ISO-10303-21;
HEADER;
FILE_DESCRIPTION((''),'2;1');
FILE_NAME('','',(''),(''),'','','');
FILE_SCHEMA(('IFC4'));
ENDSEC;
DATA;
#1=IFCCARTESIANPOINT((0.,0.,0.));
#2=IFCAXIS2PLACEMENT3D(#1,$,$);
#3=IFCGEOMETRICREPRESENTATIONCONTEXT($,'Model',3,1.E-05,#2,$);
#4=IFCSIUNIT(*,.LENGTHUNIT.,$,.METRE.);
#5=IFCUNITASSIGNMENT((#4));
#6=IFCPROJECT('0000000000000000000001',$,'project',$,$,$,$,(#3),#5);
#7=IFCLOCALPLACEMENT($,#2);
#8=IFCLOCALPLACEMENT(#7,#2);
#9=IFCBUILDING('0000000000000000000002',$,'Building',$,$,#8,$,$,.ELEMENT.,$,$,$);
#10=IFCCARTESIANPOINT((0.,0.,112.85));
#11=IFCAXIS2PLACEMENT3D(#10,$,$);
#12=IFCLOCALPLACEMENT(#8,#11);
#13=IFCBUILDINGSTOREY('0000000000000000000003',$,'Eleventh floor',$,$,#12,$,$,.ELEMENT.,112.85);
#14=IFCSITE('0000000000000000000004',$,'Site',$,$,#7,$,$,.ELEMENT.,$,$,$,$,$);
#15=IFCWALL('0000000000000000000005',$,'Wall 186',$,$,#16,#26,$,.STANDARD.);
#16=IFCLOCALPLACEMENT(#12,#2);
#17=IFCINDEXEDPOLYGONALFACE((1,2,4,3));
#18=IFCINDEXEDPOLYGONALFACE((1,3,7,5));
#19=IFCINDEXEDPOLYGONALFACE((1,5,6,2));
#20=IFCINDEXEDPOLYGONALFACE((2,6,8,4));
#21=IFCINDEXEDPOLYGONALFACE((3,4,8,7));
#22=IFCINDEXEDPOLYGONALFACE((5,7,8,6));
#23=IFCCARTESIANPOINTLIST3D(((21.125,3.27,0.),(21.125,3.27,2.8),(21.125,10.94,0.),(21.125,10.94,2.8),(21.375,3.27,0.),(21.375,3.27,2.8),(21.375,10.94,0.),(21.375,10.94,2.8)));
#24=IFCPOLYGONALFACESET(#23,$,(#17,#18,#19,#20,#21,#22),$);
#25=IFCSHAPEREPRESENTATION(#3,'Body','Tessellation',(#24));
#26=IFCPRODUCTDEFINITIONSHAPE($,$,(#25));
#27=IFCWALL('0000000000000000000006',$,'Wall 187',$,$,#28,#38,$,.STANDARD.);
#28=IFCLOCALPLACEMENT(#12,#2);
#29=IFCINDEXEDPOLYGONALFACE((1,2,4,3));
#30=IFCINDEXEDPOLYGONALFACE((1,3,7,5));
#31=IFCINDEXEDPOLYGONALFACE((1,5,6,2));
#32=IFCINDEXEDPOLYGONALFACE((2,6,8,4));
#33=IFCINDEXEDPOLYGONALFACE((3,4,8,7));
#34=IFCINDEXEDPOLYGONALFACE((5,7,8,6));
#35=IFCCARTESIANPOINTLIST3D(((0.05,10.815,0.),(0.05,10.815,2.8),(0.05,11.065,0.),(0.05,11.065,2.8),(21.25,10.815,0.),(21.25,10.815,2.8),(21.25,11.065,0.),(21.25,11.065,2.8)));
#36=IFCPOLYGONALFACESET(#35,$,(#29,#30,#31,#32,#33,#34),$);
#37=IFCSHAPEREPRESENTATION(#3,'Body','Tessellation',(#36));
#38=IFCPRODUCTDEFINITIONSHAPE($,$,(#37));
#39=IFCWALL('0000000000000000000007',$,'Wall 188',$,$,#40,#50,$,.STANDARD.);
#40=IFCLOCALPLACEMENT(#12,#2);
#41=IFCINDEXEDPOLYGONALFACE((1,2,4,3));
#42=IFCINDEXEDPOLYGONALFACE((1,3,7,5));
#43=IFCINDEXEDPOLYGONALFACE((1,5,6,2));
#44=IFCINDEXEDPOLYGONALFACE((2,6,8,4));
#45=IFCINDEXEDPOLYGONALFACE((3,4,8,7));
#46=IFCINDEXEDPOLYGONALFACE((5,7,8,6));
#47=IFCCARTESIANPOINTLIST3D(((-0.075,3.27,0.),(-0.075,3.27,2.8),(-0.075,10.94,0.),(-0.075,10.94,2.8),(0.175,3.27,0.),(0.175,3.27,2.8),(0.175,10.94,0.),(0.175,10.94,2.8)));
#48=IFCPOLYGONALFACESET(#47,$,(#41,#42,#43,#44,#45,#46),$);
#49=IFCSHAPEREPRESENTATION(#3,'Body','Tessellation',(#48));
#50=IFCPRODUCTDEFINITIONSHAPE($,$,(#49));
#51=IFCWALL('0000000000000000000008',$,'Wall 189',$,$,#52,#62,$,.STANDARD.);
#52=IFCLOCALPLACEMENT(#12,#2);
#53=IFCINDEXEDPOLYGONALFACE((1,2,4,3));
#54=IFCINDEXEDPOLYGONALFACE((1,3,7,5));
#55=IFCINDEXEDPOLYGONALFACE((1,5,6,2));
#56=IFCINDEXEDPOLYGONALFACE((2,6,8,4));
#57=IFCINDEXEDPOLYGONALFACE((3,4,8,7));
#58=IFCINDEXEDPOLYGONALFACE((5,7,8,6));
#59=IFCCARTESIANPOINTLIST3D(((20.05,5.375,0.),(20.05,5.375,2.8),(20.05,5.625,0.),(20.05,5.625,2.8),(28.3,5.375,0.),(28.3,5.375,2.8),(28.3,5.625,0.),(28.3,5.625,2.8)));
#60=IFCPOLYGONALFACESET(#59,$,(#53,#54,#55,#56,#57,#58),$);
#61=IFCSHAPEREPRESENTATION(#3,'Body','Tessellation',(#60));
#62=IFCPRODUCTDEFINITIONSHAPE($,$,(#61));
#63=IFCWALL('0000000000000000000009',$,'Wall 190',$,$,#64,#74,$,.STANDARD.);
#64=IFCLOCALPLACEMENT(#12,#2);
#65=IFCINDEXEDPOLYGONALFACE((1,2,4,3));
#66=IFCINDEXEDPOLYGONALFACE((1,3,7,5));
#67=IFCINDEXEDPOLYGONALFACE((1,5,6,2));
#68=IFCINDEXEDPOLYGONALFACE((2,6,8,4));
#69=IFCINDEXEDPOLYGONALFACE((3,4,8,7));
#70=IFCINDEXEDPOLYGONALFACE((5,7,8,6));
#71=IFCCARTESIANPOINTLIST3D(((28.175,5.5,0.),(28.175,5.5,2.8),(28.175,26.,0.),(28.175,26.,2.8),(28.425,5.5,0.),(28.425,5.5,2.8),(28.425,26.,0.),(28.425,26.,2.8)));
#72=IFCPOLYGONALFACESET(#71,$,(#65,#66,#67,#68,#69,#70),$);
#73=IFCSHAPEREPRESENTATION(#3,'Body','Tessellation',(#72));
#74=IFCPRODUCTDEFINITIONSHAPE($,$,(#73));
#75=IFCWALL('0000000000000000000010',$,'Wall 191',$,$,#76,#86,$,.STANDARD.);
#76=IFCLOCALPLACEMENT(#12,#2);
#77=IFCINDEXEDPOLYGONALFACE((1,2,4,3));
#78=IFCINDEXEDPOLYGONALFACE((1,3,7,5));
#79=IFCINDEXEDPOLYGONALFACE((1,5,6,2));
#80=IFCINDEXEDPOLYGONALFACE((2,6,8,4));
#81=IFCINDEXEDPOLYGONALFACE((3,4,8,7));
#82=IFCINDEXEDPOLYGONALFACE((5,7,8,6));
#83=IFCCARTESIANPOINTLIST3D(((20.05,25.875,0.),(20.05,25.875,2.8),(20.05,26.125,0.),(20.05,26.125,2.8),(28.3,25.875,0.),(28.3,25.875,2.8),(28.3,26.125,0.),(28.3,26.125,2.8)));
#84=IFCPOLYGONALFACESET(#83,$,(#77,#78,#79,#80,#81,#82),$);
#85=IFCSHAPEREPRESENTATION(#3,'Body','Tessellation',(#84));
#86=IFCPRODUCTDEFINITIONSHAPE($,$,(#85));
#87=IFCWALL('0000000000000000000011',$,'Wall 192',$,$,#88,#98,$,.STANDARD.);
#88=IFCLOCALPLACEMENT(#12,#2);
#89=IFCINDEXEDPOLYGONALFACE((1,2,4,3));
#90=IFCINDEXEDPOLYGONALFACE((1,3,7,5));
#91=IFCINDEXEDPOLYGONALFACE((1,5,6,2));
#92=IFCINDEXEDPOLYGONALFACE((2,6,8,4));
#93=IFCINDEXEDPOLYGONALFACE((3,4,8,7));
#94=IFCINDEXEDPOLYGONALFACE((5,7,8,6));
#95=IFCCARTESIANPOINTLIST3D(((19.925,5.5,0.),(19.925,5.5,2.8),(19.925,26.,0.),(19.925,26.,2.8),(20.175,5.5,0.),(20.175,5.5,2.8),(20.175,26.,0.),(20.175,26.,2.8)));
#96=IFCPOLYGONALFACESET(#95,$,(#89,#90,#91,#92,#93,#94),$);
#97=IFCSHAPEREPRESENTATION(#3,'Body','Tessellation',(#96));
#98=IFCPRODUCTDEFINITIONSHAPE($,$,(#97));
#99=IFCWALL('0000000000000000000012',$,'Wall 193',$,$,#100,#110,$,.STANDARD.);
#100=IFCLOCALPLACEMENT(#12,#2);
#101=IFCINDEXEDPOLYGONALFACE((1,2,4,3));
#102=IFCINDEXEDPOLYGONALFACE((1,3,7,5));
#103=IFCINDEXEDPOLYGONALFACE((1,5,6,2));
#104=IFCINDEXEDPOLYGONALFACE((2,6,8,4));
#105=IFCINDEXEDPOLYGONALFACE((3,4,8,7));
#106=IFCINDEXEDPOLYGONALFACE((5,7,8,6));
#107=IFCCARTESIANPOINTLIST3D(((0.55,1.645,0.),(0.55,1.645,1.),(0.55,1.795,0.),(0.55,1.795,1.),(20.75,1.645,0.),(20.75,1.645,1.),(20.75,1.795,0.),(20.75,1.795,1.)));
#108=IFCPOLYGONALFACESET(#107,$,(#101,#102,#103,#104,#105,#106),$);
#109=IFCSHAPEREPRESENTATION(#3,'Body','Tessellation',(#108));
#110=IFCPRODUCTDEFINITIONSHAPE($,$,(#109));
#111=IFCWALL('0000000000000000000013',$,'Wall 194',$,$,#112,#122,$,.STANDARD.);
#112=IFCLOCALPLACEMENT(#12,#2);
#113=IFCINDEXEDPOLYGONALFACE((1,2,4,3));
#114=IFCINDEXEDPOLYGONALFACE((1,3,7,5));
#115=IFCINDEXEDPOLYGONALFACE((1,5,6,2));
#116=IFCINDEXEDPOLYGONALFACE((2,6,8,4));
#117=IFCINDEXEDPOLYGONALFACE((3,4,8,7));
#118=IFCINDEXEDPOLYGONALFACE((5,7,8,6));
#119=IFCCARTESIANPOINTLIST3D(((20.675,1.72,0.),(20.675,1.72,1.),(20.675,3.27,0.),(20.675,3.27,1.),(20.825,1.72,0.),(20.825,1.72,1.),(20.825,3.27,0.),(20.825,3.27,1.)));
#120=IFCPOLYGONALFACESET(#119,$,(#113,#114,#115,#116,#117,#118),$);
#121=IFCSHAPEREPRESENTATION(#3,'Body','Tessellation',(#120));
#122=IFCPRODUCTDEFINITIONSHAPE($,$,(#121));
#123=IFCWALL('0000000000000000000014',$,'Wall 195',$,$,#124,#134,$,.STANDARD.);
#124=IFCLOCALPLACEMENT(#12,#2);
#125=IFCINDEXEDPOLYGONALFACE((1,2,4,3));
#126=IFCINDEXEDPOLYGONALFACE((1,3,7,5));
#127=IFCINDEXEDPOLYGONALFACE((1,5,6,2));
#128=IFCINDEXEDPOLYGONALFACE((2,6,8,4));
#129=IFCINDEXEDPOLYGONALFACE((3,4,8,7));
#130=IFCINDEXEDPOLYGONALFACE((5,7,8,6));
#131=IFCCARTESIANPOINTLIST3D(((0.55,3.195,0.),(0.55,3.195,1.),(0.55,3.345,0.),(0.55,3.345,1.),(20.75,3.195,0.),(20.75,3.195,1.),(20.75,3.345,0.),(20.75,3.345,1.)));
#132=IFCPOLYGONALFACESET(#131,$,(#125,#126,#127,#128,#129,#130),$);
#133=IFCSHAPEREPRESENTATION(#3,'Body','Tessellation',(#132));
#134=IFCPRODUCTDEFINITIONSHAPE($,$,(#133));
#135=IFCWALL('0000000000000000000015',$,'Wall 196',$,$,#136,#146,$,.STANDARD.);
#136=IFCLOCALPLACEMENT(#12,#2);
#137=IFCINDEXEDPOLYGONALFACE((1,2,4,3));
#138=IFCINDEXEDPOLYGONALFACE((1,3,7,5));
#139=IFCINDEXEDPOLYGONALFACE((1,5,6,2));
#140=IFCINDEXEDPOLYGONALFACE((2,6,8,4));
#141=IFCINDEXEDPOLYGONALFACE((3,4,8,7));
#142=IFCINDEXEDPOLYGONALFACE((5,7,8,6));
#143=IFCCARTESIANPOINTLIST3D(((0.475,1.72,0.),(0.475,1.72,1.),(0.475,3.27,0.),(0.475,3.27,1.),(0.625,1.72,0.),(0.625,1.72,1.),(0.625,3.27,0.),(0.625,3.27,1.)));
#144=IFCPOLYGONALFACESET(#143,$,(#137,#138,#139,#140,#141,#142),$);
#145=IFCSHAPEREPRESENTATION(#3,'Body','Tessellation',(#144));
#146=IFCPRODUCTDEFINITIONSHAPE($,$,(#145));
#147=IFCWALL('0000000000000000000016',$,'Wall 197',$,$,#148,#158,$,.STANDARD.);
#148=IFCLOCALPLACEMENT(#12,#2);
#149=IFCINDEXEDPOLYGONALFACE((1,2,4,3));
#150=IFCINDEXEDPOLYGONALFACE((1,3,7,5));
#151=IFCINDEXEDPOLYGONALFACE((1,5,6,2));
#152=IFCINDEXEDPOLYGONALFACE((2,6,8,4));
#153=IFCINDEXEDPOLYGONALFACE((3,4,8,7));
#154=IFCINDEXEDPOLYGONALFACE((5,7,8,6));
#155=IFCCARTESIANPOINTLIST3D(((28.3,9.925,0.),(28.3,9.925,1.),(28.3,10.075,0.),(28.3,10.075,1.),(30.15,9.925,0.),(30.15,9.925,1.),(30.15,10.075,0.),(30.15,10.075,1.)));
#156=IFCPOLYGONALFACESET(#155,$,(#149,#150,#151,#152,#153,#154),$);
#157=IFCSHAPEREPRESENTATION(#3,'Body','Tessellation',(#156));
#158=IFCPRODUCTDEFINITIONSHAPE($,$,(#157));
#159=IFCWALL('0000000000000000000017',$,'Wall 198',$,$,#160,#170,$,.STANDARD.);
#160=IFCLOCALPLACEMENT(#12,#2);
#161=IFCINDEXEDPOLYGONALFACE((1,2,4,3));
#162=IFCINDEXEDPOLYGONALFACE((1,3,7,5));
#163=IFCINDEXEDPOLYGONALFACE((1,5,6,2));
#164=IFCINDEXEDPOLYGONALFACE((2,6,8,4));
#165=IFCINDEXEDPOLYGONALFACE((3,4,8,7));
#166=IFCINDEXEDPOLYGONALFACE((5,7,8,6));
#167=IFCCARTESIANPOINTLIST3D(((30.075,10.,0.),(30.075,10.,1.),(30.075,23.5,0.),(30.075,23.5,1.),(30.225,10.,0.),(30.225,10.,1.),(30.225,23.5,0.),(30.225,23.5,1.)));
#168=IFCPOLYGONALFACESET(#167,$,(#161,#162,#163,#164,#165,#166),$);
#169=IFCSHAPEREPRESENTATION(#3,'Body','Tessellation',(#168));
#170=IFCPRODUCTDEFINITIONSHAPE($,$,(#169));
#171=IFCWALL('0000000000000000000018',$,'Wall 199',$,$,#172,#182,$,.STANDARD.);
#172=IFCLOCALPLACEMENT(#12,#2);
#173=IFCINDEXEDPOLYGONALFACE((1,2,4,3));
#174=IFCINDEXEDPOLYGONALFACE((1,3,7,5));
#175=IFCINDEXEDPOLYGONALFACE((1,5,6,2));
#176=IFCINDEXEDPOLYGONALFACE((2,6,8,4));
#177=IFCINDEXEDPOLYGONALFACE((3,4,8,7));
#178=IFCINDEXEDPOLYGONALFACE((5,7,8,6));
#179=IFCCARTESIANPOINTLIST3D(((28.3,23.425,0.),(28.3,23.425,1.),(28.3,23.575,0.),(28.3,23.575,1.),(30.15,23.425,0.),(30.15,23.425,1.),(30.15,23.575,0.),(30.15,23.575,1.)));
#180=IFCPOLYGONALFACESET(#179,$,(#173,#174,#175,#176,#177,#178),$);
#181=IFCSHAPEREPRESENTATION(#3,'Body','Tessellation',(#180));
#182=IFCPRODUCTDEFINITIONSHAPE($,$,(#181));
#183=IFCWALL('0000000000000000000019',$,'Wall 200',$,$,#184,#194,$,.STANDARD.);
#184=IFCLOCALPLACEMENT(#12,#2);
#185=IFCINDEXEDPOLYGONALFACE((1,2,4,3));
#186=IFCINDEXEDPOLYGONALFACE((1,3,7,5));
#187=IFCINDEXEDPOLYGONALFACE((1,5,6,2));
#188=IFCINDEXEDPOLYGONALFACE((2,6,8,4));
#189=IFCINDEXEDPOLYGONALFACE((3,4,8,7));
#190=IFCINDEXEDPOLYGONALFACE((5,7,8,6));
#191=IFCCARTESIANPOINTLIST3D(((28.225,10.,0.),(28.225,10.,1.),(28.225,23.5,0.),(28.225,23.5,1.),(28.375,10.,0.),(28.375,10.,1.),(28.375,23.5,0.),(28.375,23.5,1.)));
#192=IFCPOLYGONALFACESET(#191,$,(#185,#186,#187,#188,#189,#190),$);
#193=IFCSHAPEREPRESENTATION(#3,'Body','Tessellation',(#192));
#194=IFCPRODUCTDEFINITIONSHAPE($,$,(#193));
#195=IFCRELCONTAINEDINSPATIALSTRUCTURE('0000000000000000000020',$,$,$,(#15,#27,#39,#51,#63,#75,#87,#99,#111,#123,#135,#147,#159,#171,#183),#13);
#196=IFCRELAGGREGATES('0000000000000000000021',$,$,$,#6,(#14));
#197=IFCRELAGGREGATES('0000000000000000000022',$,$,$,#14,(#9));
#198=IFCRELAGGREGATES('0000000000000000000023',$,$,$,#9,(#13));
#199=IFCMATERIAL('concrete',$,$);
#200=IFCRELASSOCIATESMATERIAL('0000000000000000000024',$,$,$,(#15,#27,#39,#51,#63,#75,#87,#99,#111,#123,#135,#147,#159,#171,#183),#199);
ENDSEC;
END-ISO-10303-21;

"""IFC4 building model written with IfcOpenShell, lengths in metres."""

from ifc_helpers import new_model, si_unit, frame, frame_2d, origin, place, context, project, spatial, rectangle, extrude, material, element, save


model = new_model("IFC4")

# Units and contexts
model_context = context("Model", 3, precision=1e-05, world=origin())
ifc_project = project(units=[si_unit("LENGTHUNIT", "METRE")], contexts=[model_context])

# Site, building, storey
site_placement = place(None, origin())
site = spatial("IfcSite", under=ifc_project, at=site_placement, Name="Site", CompositionType="ELEMENT")
building_placement = place(site_placement, origin())
building = spatial("IfcBuilding", under=site, at=building_placement, Name="Building", CompositionType="ELEMENT")
storey_placement = place(building_placement, frame((0.0, 0.0, 112.85)))
storey = spatial("IfcBuildingStorey", under=building, at=storey_placement, Name="Eleventh floor", CompositionType="ELEMENT", Elevation=112.85)

# Shared definitions
ifc_material = material(Name="concrete")

# Walls
wall_1_placement = place(storey_placement, frame((21.25, 3.27, 0.0), z_axis=(0.0, 0.0, 1.0), x_axis=(0.0, 1.0, 0.0)))
element("IfcWall", 1, at=wall_1_placement, inside=storey, material=ifc_material, Name="Wall 186", PredefinedType="STANDARD", context=model_context, shape_type="SweptSolid", body=[
    extrude(rectangle(XDim=7.67, YDim=0.25, at=frame_2d((3.835, 0.0))), origin(), (0.0, 0.0, 1.0), 2.8),
])
wall_2_placement = place(storey_placement, frame((21.25, 10.94, 0.0), z_axis=(0.0, 0.0, 1.0), x_axis=(-1.0, 0.0, 0.0)))
element("IfcWall", 2, at=wall_2_placement, inside=storey, material=ifc_material, Name="Wall 187", PredefinedType="STANDARD", context=model_context, shape_type="SweptSolid", body=[
    extrude(rectangle(XDim=21.2, YDim=0.25, at=frame_2d((10.6, 0.0))), origin(), (0.0, 0.0, 1.0), 2.8),
])
wall_3_placement = place(storey_placement, frame((0.05, 10.94, 0.0), z_axis=(0.0, 0.0, 1.0), x_axis=(0.0, -1.0, 0.0)))
element("IfcWall", 3, at=wall_3_placement, inside=storey, material=ifc_material, Name="Wall 188", PredefinedType="STANDARD", context=model_context, shape_type="SweptSolid", body=[
    extrude(rectangle(XDim=7.67, YDim=0.25, at=frame_2d((3.835, 0.0))), origin(), (0.0, 0.0, 1.0), 2.8),
])
wall_4_placement = place(storey_placement, frame((20.05, 5.5, 0.0), z_axis=(0.0, 0.0, 1.0), x_axis=(1.0, 0.0, 0.0)))
element("IfcWall", 4, at=wall_4_placement, inside=storey, material=ifc_material, Name="Wall 189", PredefinedType="STANDARD", context=model_context, shape_type="SweptSolid", body=[
    extrude(rectangle(XDim=8.25, YDim=0.25, at=frame_2d((4.125, 0.0))), origin(), (0.0, 0.0, 1.0), 2.8),
])
wall_5_placement = place(storey_placement, frame((28.3, 5.5, 0.0), z_axis=(0.0, 0.0, 1.0), x_axis=(0.0, 1.0, 0.0)))
element("IfcWall", 5, at=wall_5_placement, inside=storey, material=ifc_material, Name="Wall 190", PredefinedType="STANDARD", context=model_context, shape_type="SweptSolid", body=[
    extrude(rectangle(XDim=20.5, YDim=0.25, at=frame_2d((10.25, 0.0))), origin(), (0.0, 0.0, 1.0), 2.8),
])
wall_6_placement = place(storey_placement, frame((28.3, 26.0, 0.0), z_axis=(0.0, 0.0, 1.0), x_axis=(-1.0, 0.0, 0.0)))
element("IfcWall", 6, at=wall_6_placement, inside=storey, material=ifc_material, Name="Wall 191", PredefinedType="STANDARD", context=model_context, shape_type="SweptSolid", body=[
    extrude(rectangle(XDim=8.25, YDim=0.25, at=frame_2d((4.125, 0.0))), origin(), (0.0, 0.0, 1.0), 2.8),
])
wall_7_placement = place(storey_placement, frame((20.05, 26.0, 0.0), z_axis=(0.0, 0.0, 1.0), x_axis=(0.0, -1.0, 0.0)))
element("IfcWall", 7, at=wall_7_placement, inside=storey, material=ifc_material, Name="Wall 192", PredefinedType="STANDARD", context=model_context, shape_type="SweptSolid", body=[
    extrude(rectangle(XDim=20.5, YDim=0.25, at=frame_2d((10.25, 0.0))), origin(), (0.0, 0.0, 1.0), 2.8),
])
wall_8_placement = place(storey_placement, frame((0.55, 1.72, 0.0), z_axis=(0.0, 0.0, 1.0), x_axis=(1.0, 0.0, 0.0)))
element("IfcWall", 8, at=wall_8_placement, inside=storey, material=ifc_material, Name="Wall 193", PredefinedType="STANDARD", context=model_context, shape_type="SweptSolid", body=[
    extrude(rectangle(XDim=20.2, YDim=0.15, at=frame_2d((10.1, 0.0))), origin(), (0.0, 0.0, 1.0), 1.0),
])
wall_9_placement = place(storey_placement, frame((20.75, 1.72, 0.0), z_axis=(0.0, 0.0, 1.0), x_axis=(0.0, 1.0, 0.0)))
element("IfcWall", 9, at=wall_9_placement, inside=storey, material=ifc_material, Name="Wall 194", PredefinedType="STANDARD", context=model_context, shape_type="SweptSolid", body=[
    extrude(rectangle(XDim=1.55, YDim=0.15, at=frame_2d((0.775, 0.0))), origin(), (0.0, 0.0, 1.0), 1.0),
])
wall_10_placement = place(storey_placement, frame((20.75, 3.27, 0.0), z_axis=(0.0, 0.0, 1.0), x_axis=(-1.0, 0.0, 0.0)))
element("IfcWall", 10, at=wall_10_placement, inside=storey, material=ifc_material, Name="Wall 195", PredefinedType="STANDARD", context=model_context, shape_type="SweptSolid", body=[
    extrude(rectangle(XDim=20.2, YDim=0.15, at=frame_2d((10.1, 0.0))), origin(), (0.0, 0.0, 1.0), 1.0),
])
wall_11_placement = place(storey_placement, frame((0.55, 3.27, 0.0), z_axis=(0.0, 0.0, 1.0), x_axis=(0.0, -1.0, 0.0)))
element("IfcWall", 11, at=wall_11_placement, inside=storey, material=ifc_material, Name="Wall 196", PredefinedType="STANDARD", context=model_context, shape_type="SweptSolid", body=[
    extrude(rectangle(XDim=1.55, YDim=0.15, at=frame_2d((0.775, 0.0))), origin(), (0.0, 0.0, 1.0), 1.0),
])
wall_12_placement = place(storey_placement, frame((28.3, 10.0, 0.0), z_axis=(0.0, 0.0, 1.0), x_axis=(1.0, 0.0, 0.0)))
element("IfcWall", 12, at=wall_12_placement, inside=storey, material=ifc_material, Name="Wall 197", PredefinedType="STANDARD", context=model_context, shape_type="SweptSolid", body=[
    extrude(rectangle(XDim=1.85, YDim=0.15, at=frame_2d((0.925, 0.0))), origin(), (0.0, 0.0, 1.0), 1.0),
])
wall_13_placement = place(storey_placement, frame((30.15, 10.0, 0.0), z_axis=(0.0, 0.0, 1.0), x_axis=(0.0, 1.0, 0.0)))
element("IfcWall", 13, at=wall_13_placement, inside=storey, material=ifc_material, Name="Wall 198", PredefinedType="STANDARD", context=model_context, shape_type="SweptSolid", body=[
    extrude(rectangle(XDim=13.5, YDim=0.15, at=frame_2d((6.75, 0.0))), origin(), (0.0, 0.0, 1.0), 1.0),
])
wall_14_placement = place(storey_placement, frame((30.15, 23.5, 0.0), z_axis=(0.0, 0.0, 1.0), x_axis=(-1.0, 0.0, 0.0)))
element("IfcWall", 14, at=wall_14_placement, inside=storey, material=ifc_material, Name="Wall 199", PredefinedType="STANDARD", context=model_context, shape_type="SweptSolid", body=[
    extrude(rectangle(XDim=1.85, YDim=0.15, at=frame_2d((0.925, 0.0))), origin(), (0.0, 0.0, 1.0), 1.0),
])
wall_15_placement = place(storey_placement, frame((28.3, 23.5, 0.0), z_axis=(0.0, 0.0, 1.0), x_axis=(0.0, -1.0, 0.0)))
element("IfcWall", 15, at=wall_15_placement, inside=storey, material=ifc_material, Name="Wall 200", PredefinedType="STANDARD", context=model_context, shape_type="SweptSolid", body=[
    extrude(rectangle(XDim=13.5, YDim=0.15, at=frame_2d((6.75, 0.0))), origin(), (0.0, 0.0, 1.0), 1.0),
])

save(model, "model.ifc")
